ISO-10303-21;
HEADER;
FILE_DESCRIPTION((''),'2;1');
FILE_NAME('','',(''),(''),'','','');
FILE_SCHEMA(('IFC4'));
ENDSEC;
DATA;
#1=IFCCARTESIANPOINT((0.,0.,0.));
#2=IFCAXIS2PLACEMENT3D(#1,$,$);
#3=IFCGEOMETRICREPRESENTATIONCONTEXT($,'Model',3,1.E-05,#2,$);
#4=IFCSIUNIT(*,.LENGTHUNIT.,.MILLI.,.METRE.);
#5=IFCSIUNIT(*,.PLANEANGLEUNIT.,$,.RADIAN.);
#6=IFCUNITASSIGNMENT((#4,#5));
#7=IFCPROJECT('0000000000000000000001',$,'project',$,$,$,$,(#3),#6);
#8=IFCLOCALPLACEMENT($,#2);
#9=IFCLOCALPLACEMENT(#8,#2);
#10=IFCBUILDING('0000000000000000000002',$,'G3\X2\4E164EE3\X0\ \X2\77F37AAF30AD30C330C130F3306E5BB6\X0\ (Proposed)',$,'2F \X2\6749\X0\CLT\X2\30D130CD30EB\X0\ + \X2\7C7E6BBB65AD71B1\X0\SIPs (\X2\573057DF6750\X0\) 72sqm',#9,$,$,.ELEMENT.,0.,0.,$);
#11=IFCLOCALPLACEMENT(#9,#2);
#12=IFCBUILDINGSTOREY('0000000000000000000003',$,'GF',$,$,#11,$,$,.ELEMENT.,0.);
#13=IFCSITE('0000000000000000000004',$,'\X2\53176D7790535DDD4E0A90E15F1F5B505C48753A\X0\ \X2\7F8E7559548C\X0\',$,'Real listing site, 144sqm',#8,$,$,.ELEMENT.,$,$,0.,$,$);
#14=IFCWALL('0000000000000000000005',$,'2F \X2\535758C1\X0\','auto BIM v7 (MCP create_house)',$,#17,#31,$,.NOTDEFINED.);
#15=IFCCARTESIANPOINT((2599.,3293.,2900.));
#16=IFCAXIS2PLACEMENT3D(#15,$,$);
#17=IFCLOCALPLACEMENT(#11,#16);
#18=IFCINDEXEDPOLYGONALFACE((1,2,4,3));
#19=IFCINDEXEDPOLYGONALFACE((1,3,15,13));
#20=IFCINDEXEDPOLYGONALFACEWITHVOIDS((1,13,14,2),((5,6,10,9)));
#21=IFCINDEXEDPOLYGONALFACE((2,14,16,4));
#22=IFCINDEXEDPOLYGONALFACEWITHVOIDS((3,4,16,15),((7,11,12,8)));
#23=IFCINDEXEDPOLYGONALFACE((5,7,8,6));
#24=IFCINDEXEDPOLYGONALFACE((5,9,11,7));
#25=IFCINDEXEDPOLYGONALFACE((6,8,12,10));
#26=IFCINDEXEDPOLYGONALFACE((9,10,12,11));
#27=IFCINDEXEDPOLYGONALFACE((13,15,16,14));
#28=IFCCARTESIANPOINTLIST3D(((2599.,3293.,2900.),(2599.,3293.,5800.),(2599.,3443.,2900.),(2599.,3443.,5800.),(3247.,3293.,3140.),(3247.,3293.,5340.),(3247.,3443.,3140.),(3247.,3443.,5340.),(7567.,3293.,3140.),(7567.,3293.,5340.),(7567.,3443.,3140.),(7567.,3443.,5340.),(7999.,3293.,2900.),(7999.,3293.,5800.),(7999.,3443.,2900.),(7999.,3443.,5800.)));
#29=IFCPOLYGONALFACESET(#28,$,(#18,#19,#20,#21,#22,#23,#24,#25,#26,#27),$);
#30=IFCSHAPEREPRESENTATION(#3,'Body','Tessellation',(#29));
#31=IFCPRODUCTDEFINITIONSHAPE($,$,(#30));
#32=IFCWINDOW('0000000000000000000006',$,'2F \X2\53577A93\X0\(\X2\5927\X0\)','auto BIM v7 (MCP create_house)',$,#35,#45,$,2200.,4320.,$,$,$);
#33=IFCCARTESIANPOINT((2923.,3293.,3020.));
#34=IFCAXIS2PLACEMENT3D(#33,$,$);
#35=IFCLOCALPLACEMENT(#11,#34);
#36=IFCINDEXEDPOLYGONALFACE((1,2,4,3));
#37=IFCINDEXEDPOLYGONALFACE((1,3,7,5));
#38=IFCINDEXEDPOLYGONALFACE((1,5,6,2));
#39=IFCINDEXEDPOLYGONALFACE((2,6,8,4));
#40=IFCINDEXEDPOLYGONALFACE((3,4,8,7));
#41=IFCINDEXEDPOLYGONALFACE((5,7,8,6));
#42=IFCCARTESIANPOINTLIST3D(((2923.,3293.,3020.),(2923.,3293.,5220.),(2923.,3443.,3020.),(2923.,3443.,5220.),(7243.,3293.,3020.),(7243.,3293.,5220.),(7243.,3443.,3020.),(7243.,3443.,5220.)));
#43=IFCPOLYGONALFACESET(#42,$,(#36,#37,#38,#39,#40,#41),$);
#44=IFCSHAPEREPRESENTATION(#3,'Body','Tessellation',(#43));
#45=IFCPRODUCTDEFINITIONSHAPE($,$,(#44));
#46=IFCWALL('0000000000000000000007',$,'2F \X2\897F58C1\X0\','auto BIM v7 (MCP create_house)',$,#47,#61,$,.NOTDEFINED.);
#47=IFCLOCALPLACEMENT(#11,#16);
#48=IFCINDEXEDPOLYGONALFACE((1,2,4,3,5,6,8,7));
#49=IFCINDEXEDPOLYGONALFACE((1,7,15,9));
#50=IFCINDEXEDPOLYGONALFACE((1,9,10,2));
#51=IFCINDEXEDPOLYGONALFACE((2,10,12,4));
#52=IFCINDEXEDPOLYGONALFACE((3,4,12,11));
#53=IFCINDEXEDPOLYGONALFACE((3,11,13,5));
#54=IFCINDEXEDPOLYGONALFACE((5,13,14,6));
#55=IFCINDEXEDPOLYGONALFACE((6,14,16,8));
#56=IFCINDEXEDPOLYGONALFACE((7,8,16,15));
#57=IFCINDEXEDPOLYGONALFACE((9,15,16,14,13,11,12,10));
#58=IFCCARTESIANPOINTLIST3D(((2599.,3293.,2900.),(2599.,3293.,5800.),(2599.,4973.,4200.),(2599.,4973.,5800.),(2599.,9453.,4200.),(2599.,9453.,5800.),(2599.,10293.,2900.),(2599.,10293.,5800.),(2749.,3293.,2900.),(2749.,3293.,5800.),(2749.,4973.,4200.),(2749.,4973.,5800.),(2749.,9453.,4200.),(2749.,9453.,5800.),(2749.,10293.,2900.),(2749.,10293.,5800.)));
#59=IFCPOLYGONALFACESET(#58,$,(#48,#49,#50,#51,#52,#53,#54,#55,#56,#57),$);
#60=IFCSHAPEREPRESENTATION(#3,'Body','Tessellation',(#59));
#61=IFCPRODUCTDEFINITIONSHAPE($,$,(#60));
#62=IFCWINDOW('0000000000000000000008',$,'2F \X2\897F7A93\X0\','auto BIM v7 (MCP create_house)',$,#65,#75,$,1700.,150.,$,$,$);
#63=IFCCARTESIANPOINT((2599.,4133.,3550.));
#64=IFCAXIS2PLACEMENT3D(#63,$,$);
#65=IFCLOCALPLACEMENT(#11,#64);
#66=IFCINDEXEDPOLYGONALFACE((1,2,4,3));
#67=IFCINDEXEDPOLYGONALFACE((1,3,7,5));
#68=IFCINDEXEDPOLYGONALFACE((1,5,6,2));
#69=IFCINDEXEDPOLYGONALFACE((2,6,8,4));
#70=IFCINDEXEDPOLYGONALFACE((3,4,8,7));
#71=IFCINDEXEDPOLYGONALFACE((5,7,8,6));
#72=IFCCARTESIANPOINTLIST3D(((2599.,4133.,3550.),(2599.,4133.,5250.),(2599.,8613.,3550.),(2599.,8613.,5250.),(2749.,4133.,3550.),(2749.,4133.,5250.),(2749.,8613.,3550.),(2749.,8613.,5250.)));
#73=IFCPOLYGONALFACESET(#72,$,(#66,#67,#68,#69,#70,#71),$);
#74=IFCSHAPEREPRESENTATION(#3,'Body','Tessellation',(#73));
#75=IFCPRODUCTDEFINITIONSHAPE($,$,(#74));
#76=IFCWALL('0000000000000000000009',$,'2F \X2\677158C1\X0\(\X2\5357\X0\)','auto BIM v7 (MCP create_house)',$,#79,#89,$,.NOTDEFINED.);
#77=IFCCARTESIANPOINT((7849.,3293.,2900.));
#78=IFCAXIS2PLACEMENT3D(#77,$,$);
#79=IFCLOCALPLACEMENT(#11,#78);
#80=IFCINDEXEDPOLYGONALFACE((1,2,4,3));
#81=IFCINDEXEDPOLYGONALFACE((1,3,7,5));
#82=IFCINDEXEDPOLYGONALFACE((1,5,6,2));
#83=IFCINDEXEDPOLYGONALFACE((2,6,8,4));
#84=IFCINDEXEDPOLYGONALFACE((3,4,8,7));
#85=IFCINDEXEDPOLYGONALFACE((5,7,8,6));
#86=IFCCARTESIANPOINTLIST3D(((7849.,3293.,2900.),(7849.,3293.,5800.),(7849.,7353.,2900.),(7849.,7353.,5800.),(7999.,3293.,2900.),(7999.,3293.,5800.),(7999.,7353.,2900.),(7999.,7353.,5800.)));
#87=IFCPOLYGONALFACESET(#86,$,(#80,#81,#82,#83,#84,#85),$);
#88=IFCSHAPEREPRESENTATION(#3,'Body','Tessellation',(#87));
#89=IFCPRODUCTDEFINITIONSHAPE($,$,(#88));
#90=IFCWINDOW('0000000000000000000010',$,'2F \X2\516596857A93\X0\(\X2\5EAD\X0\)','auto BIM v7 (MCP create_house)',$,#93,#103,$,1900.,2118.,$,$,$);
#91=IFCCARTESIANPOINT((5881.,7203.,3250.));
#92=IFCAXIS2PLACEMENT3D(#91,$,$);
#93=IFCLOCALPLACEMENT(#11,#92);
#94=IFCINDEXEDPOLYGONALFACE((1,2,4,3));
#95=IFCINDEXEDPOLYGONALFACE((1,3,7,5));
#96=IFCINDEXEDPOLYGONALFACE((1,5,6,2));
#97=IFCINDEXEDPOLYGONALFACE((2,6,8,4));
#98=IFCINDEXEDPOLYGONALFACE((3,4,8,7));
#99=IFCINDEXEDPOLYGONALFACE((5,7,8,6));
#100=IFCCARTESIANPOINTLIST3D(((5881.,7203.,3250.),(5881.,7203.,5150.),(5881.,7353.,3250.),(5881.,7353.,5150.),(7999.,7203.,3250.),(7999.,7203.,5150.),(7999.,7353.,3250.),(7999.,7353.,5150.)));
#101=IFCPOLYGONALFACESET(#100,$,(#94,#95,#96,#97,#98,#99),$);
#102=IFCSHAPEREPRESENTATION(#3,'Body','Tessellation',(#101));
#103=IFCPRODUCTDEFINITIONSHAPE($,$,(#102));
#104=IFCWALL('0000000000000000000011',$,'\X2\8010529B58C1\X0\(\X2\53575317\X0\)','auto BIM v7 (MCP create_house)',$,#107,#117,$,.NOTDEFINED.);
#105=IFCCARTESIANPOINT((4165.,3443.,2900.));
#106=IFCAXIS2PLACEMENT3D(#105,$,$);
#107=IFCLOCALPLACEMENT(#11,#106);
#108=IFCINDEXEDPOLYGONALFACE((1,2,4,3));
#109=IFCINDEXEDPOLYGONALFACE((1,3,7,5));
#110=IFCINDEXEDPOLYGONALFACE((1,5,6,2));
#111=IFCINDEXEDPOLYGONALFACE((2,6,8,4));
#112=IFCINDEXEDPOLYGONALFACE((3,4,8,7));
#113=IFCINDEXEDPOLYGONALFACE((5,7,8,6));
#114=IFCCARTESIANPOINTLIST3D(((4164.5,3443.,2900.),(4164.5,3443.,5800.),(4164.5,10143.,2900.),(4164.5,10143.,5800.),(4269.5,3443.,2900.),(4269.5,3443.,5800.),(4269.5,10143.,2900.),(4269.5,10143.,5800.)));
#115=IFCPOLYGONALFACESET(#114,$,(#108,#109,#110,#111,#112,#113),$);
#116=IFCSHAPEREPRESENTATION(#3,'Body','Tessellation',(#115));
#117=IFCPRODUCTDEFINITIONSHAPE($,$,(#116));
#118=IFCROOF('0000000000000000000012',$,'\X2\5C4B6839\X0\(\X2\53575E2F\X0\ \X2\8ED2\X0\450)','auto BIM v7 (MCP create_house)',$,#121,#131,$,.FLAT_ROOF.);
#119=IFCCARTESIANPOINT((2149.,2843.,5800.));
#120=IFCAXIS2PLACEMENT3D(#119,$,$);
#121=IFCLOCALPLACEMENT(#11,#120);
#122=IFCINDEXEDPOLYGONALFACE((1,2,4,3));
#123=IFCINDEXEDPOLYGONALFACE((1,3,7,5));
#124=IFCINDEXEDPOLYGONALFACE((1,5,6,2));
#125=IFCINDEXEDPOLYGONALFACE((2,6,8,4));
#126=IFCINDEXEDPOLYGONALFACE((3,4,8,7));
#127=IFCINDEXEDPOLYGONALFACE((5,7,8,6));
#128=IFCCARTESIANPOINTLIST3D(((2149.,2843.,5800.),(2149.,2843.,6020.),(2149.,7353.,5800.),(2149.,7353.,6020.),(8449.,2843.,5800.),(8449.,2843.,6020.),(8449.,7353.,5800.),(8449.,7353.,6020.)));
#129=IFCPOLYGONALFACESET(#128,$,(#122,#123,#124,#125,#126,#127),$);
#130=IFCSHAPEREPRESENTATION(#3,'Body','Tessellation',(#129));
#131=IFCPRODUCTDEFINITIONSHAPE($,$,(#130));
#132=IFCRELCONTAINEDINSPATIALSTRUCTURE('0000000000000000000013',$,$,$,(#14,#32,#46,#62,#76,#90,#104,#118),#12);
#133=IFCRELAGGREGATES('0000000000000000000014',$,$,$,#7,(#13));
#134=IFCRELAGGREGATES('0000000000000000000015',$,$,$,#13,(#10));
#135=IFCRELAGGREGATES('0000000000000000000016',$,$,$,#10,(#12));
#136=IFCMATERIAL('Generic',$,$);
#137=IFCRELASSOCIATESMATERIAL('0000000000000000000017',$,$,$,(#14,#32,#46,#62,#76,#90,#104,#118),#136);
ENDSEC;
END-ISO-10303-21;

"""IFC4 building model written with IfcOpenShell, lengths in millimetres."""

from ifc_helpers import new_model, si_unit, frame, frame_2d, origin, place, context, project, spatial, rectangle, extrude, material, element, fill, save


model = new_model("IFC4")

# Units and contexts
model_context = context("Model", 3, precision=1e-05, world=origin())
ifc_project = project(units=[si_unit("LENGTHUNIT", "METRE", prefix="MILLI"), si_unit("PLANEANGLEUNIT", "RADIAN")], contexts=[model_context])

# Site, building, storey
site_placement = place(None, origin())
site = spatial("IfcSite", under=ifc_project, at=site_placement, Name="北海道川上郡弟子屈町 美留和", ObjectType="Real listing site, 144sqm", CompositionType="ELEMENT", RefElevation=0.0)
building_placement = place(site_placement, origin())
building = spatial("IfcBuilding", under=site, at=building_placement, Name="G3世代 石窯キッチンの家 (Proposed)", ObjectType="2F 杉CLTパネル + 籾殻断熱SIPs (地域材) 72sqm", CompositionType="ELEMENT", ElevationOfRefHeight=0.0, ElevationOfTerrain=0.0)
storey_placement = place(building_placement, origin())
storey = spatial("IfcBuildingStorey", under=building, at=storey_placement, Name="GF", CompositionType="ELEMENT", Elevation=0.0)

# Shared definitions
ifc_material = material(Name="Generic")

# Walls, openings, windows
wall_1_placement = place(storey_placement, frame((2599.0, 3293.0, 2900.0)))
wall_1 = element("IfcWall", 1, at=wall_1_placement, inside=storey, material=ifc_material, Name="2F 南壁", Description="auto BIM v7 (MCP create_house)", PredefinedType="NOTDEFINED", context=model_context, shape_type="SweptSolid", body=[
    extrude(rectangle(XDim=5400.0, YDim=150.0, at=frame_2d((2700.0, 75.0))), frame((2599.0, 3293.0, 2900.0)), (0.0, 0.0, 1.0), 2900.0),
])
opening_1_placement = place(storey_placement, frame((2923.0, 3293.0, 3020.0)))
opening_1 = element("IfcOpeningElement", 2, at=opening_1_placement, cuts=wall_1, PredefinedType="NOTDEFINED", context=model_context, shape_type="SweptSolid", body=[
    extrude(rectangle(XDim=4320.0, YDim=150.0, at=frame_2d((2160.0, 75.0))), frame((2923.0, 3293.0, 3020.0)), (0.0, 0.0, 1.0), 2200.0),
])
window_1_placement = place(storey_placement, frame((2923.0, 3293.0, 3020.0)))
window_1 = element("IfcWindow", 3, at=window_1_placement, inside=storey, material=ifc_material, Name="2F 南窓(大)", Description="auto BIM v7 (MCP create_house)", OverallHeight=2200.0, OverallWidth=4320.0, context=model_context, shape_type="SweptSolid", body=[
    extrude(rectangle(XDim=4320.0, YDim=150.0, at=frame_2d((2160.0, 75.0))), frame((2923.0, 3293.0, 3020.0)), (0.0, 0.0, 1.0), 2200.0),
])
fill(opening_1, window_1)
wall_2_placement = place(storey_placement, frame((2599.0, 3293.0, 2900.0)))
wall_2 = element("IfcWall", 4, at=wall_2_placement, inside=storey, material=ifc_material, Name="2F 西壁", Description="auto BIM v7 (MCP create_house)", PredefinedType="NOTDEFINED", context=model_context, shape_type="SweptSolid", body=[
    extrude(rectangle(XDim=150.0, YDim=7000.0, at=frame_2d((75.0, 3500.0))), frame((2599.0, 3293.0, 2900.0)), (0.0, 0.0, 1.0), 2900.0),
])
opening_2_placement = place(storey_placement, frame((2599.0, 4133.0, 3550.0)))
opening_2 = element("IfcOpeningElement", 5, at=opening_2_placement, cuts=wall_2, PredefinedType="NOTDEFINED", context=model_context, shape_type="SweptSolid", body=[
    extrude(rectangle(XDim=150.0, YDim=4480.0, at=frame_2d((75.0, 2240.0))), frame((2599.0, 4133.0, 3550.0)), (0.0, 0.0, 1.0), 1700.0),
])
window_2_placement = place(storey_placement, frame((2599.0, 4133.0, 3550.0)))
window_2 = element("IfcWindow", 6, at=window_2_placement, inside=storey, material=ifc_material, Name="2F 西窓", Description="auto BIM v7 (MCP create_house)", OverallHeight=1700.0, OverallWidth=150.0, context=model_context, shape_type="SweptSolid", body=[
    extrude(rectangle(XDim=150.0, YDim=4480.0, at=frame_2d((75.0, 2240.0))), frame((2599.0, 4133.0, 3550.0)), (0.0, 0.0, 1.0), 1700.0),
])
fill(opening_2, window_2)
wall_3_placement = place(storey_placement, frame((7849.0, 3293.0, 2900.0)))
wall_3 = element("IfcWall", 7, at=wall_3_placement, inside=storey, material=ifc_material, Name="2F 東壁(南)", Description="auto BIM v7 (MCP create_house)", PredefinedType="NOTDEFINED", context=model_context, shape_type="SweptSolid", body=[
    extrude(rectangle(XDim=150.0, YDim=4060.0, at=frame_2d((75.0, 2030.0))), frame((7849.0, 3293.0, 2900.0)), (0.0, 0.0, 1.0), 2900.0),
])
opening_3_placement = place(storey_placement, frame((5881.0, 7203.0, 3250.0)))
opening_3 = element("IfcOpeningElement", 8, at=opening_3_placement, cuts=wall_3, PredefinedType="NOTDEFINED", context=model_context, shape_type="SweptSolid", body=[
    extrude(rectangle(XDim=2118.0, YDim=150.0, at=frame_2d((1059.0, 75.0))), frame((5881.0, 7203.0, 3250.0)), (0.0, 0.0, 1.0), 1900.0),
])
window_3_placement = place(storey_placement, frame((5881.0, 7203.0, 3250.0)))
window_3 = element("IfcWindow", 9, at=window_3_placement, inside=storey, material=ifc_material, Name="2F 入隅窓(庭)", Description="auto BIM v7 (MCP create_house)", OverallHeight=1900.0, OverallWidth=2118.0, context=model_context, shape_type="SweptSolid", body=[
    extrude(rectangle(XDim=2118.0, YDim=150.0, at=frame_2d((1059.0, 75.0))), frame((5881.0, 7203.0, 3250.0)), (0.0, 0.0, 1.0), 1900.0),
])
fill(opening_3, window_3)

# Wall
wall_4_placement = place(storey_placement, frame((4165.0, 3443.0, 2900.0)))
element("IfcWall", 10, at=wall_4_placement, inside=storey, material=ifc_material, Name="耐力壁(南北)", Description="auto BIM v7 (MCP create_house)", PredefinedType="NOTDEFINED", context=model_context, shape_type="SweptSolid", body=[
    extrude(rectangle(XDim=105.0, YDim=6700.0, at=frame_2d((52.0, 3350.0))), frame((4165.0, 3443.0, 2900.0)), (0.0, 0.0, 1.0), 2900.0),
])

# Roof
for number, where, name in (
    (11, (2149.0, 2843.0, 5800.0), "屋根(南帯 軒450)"),
):
    element("IfcRoof", number, at=place(storey_placement, frame(where)), inside=storey, material=ifc_material, Name=name, Description="auto BIM v7 (MCP create_house)", PredefinedType="FLAT_ROOF", context=model_context, shape_type="SweptSolid", body=[
        extrude(rectangle(XDim=6300.0, YDim=4510.0, at=frame_2d((3150.0, 2255.0))), frame((2149.0, 2843.0, 5800.0)), (0.0, 0.0, 1.0), 220.0),
    ])

save(model, "model.ifc")
